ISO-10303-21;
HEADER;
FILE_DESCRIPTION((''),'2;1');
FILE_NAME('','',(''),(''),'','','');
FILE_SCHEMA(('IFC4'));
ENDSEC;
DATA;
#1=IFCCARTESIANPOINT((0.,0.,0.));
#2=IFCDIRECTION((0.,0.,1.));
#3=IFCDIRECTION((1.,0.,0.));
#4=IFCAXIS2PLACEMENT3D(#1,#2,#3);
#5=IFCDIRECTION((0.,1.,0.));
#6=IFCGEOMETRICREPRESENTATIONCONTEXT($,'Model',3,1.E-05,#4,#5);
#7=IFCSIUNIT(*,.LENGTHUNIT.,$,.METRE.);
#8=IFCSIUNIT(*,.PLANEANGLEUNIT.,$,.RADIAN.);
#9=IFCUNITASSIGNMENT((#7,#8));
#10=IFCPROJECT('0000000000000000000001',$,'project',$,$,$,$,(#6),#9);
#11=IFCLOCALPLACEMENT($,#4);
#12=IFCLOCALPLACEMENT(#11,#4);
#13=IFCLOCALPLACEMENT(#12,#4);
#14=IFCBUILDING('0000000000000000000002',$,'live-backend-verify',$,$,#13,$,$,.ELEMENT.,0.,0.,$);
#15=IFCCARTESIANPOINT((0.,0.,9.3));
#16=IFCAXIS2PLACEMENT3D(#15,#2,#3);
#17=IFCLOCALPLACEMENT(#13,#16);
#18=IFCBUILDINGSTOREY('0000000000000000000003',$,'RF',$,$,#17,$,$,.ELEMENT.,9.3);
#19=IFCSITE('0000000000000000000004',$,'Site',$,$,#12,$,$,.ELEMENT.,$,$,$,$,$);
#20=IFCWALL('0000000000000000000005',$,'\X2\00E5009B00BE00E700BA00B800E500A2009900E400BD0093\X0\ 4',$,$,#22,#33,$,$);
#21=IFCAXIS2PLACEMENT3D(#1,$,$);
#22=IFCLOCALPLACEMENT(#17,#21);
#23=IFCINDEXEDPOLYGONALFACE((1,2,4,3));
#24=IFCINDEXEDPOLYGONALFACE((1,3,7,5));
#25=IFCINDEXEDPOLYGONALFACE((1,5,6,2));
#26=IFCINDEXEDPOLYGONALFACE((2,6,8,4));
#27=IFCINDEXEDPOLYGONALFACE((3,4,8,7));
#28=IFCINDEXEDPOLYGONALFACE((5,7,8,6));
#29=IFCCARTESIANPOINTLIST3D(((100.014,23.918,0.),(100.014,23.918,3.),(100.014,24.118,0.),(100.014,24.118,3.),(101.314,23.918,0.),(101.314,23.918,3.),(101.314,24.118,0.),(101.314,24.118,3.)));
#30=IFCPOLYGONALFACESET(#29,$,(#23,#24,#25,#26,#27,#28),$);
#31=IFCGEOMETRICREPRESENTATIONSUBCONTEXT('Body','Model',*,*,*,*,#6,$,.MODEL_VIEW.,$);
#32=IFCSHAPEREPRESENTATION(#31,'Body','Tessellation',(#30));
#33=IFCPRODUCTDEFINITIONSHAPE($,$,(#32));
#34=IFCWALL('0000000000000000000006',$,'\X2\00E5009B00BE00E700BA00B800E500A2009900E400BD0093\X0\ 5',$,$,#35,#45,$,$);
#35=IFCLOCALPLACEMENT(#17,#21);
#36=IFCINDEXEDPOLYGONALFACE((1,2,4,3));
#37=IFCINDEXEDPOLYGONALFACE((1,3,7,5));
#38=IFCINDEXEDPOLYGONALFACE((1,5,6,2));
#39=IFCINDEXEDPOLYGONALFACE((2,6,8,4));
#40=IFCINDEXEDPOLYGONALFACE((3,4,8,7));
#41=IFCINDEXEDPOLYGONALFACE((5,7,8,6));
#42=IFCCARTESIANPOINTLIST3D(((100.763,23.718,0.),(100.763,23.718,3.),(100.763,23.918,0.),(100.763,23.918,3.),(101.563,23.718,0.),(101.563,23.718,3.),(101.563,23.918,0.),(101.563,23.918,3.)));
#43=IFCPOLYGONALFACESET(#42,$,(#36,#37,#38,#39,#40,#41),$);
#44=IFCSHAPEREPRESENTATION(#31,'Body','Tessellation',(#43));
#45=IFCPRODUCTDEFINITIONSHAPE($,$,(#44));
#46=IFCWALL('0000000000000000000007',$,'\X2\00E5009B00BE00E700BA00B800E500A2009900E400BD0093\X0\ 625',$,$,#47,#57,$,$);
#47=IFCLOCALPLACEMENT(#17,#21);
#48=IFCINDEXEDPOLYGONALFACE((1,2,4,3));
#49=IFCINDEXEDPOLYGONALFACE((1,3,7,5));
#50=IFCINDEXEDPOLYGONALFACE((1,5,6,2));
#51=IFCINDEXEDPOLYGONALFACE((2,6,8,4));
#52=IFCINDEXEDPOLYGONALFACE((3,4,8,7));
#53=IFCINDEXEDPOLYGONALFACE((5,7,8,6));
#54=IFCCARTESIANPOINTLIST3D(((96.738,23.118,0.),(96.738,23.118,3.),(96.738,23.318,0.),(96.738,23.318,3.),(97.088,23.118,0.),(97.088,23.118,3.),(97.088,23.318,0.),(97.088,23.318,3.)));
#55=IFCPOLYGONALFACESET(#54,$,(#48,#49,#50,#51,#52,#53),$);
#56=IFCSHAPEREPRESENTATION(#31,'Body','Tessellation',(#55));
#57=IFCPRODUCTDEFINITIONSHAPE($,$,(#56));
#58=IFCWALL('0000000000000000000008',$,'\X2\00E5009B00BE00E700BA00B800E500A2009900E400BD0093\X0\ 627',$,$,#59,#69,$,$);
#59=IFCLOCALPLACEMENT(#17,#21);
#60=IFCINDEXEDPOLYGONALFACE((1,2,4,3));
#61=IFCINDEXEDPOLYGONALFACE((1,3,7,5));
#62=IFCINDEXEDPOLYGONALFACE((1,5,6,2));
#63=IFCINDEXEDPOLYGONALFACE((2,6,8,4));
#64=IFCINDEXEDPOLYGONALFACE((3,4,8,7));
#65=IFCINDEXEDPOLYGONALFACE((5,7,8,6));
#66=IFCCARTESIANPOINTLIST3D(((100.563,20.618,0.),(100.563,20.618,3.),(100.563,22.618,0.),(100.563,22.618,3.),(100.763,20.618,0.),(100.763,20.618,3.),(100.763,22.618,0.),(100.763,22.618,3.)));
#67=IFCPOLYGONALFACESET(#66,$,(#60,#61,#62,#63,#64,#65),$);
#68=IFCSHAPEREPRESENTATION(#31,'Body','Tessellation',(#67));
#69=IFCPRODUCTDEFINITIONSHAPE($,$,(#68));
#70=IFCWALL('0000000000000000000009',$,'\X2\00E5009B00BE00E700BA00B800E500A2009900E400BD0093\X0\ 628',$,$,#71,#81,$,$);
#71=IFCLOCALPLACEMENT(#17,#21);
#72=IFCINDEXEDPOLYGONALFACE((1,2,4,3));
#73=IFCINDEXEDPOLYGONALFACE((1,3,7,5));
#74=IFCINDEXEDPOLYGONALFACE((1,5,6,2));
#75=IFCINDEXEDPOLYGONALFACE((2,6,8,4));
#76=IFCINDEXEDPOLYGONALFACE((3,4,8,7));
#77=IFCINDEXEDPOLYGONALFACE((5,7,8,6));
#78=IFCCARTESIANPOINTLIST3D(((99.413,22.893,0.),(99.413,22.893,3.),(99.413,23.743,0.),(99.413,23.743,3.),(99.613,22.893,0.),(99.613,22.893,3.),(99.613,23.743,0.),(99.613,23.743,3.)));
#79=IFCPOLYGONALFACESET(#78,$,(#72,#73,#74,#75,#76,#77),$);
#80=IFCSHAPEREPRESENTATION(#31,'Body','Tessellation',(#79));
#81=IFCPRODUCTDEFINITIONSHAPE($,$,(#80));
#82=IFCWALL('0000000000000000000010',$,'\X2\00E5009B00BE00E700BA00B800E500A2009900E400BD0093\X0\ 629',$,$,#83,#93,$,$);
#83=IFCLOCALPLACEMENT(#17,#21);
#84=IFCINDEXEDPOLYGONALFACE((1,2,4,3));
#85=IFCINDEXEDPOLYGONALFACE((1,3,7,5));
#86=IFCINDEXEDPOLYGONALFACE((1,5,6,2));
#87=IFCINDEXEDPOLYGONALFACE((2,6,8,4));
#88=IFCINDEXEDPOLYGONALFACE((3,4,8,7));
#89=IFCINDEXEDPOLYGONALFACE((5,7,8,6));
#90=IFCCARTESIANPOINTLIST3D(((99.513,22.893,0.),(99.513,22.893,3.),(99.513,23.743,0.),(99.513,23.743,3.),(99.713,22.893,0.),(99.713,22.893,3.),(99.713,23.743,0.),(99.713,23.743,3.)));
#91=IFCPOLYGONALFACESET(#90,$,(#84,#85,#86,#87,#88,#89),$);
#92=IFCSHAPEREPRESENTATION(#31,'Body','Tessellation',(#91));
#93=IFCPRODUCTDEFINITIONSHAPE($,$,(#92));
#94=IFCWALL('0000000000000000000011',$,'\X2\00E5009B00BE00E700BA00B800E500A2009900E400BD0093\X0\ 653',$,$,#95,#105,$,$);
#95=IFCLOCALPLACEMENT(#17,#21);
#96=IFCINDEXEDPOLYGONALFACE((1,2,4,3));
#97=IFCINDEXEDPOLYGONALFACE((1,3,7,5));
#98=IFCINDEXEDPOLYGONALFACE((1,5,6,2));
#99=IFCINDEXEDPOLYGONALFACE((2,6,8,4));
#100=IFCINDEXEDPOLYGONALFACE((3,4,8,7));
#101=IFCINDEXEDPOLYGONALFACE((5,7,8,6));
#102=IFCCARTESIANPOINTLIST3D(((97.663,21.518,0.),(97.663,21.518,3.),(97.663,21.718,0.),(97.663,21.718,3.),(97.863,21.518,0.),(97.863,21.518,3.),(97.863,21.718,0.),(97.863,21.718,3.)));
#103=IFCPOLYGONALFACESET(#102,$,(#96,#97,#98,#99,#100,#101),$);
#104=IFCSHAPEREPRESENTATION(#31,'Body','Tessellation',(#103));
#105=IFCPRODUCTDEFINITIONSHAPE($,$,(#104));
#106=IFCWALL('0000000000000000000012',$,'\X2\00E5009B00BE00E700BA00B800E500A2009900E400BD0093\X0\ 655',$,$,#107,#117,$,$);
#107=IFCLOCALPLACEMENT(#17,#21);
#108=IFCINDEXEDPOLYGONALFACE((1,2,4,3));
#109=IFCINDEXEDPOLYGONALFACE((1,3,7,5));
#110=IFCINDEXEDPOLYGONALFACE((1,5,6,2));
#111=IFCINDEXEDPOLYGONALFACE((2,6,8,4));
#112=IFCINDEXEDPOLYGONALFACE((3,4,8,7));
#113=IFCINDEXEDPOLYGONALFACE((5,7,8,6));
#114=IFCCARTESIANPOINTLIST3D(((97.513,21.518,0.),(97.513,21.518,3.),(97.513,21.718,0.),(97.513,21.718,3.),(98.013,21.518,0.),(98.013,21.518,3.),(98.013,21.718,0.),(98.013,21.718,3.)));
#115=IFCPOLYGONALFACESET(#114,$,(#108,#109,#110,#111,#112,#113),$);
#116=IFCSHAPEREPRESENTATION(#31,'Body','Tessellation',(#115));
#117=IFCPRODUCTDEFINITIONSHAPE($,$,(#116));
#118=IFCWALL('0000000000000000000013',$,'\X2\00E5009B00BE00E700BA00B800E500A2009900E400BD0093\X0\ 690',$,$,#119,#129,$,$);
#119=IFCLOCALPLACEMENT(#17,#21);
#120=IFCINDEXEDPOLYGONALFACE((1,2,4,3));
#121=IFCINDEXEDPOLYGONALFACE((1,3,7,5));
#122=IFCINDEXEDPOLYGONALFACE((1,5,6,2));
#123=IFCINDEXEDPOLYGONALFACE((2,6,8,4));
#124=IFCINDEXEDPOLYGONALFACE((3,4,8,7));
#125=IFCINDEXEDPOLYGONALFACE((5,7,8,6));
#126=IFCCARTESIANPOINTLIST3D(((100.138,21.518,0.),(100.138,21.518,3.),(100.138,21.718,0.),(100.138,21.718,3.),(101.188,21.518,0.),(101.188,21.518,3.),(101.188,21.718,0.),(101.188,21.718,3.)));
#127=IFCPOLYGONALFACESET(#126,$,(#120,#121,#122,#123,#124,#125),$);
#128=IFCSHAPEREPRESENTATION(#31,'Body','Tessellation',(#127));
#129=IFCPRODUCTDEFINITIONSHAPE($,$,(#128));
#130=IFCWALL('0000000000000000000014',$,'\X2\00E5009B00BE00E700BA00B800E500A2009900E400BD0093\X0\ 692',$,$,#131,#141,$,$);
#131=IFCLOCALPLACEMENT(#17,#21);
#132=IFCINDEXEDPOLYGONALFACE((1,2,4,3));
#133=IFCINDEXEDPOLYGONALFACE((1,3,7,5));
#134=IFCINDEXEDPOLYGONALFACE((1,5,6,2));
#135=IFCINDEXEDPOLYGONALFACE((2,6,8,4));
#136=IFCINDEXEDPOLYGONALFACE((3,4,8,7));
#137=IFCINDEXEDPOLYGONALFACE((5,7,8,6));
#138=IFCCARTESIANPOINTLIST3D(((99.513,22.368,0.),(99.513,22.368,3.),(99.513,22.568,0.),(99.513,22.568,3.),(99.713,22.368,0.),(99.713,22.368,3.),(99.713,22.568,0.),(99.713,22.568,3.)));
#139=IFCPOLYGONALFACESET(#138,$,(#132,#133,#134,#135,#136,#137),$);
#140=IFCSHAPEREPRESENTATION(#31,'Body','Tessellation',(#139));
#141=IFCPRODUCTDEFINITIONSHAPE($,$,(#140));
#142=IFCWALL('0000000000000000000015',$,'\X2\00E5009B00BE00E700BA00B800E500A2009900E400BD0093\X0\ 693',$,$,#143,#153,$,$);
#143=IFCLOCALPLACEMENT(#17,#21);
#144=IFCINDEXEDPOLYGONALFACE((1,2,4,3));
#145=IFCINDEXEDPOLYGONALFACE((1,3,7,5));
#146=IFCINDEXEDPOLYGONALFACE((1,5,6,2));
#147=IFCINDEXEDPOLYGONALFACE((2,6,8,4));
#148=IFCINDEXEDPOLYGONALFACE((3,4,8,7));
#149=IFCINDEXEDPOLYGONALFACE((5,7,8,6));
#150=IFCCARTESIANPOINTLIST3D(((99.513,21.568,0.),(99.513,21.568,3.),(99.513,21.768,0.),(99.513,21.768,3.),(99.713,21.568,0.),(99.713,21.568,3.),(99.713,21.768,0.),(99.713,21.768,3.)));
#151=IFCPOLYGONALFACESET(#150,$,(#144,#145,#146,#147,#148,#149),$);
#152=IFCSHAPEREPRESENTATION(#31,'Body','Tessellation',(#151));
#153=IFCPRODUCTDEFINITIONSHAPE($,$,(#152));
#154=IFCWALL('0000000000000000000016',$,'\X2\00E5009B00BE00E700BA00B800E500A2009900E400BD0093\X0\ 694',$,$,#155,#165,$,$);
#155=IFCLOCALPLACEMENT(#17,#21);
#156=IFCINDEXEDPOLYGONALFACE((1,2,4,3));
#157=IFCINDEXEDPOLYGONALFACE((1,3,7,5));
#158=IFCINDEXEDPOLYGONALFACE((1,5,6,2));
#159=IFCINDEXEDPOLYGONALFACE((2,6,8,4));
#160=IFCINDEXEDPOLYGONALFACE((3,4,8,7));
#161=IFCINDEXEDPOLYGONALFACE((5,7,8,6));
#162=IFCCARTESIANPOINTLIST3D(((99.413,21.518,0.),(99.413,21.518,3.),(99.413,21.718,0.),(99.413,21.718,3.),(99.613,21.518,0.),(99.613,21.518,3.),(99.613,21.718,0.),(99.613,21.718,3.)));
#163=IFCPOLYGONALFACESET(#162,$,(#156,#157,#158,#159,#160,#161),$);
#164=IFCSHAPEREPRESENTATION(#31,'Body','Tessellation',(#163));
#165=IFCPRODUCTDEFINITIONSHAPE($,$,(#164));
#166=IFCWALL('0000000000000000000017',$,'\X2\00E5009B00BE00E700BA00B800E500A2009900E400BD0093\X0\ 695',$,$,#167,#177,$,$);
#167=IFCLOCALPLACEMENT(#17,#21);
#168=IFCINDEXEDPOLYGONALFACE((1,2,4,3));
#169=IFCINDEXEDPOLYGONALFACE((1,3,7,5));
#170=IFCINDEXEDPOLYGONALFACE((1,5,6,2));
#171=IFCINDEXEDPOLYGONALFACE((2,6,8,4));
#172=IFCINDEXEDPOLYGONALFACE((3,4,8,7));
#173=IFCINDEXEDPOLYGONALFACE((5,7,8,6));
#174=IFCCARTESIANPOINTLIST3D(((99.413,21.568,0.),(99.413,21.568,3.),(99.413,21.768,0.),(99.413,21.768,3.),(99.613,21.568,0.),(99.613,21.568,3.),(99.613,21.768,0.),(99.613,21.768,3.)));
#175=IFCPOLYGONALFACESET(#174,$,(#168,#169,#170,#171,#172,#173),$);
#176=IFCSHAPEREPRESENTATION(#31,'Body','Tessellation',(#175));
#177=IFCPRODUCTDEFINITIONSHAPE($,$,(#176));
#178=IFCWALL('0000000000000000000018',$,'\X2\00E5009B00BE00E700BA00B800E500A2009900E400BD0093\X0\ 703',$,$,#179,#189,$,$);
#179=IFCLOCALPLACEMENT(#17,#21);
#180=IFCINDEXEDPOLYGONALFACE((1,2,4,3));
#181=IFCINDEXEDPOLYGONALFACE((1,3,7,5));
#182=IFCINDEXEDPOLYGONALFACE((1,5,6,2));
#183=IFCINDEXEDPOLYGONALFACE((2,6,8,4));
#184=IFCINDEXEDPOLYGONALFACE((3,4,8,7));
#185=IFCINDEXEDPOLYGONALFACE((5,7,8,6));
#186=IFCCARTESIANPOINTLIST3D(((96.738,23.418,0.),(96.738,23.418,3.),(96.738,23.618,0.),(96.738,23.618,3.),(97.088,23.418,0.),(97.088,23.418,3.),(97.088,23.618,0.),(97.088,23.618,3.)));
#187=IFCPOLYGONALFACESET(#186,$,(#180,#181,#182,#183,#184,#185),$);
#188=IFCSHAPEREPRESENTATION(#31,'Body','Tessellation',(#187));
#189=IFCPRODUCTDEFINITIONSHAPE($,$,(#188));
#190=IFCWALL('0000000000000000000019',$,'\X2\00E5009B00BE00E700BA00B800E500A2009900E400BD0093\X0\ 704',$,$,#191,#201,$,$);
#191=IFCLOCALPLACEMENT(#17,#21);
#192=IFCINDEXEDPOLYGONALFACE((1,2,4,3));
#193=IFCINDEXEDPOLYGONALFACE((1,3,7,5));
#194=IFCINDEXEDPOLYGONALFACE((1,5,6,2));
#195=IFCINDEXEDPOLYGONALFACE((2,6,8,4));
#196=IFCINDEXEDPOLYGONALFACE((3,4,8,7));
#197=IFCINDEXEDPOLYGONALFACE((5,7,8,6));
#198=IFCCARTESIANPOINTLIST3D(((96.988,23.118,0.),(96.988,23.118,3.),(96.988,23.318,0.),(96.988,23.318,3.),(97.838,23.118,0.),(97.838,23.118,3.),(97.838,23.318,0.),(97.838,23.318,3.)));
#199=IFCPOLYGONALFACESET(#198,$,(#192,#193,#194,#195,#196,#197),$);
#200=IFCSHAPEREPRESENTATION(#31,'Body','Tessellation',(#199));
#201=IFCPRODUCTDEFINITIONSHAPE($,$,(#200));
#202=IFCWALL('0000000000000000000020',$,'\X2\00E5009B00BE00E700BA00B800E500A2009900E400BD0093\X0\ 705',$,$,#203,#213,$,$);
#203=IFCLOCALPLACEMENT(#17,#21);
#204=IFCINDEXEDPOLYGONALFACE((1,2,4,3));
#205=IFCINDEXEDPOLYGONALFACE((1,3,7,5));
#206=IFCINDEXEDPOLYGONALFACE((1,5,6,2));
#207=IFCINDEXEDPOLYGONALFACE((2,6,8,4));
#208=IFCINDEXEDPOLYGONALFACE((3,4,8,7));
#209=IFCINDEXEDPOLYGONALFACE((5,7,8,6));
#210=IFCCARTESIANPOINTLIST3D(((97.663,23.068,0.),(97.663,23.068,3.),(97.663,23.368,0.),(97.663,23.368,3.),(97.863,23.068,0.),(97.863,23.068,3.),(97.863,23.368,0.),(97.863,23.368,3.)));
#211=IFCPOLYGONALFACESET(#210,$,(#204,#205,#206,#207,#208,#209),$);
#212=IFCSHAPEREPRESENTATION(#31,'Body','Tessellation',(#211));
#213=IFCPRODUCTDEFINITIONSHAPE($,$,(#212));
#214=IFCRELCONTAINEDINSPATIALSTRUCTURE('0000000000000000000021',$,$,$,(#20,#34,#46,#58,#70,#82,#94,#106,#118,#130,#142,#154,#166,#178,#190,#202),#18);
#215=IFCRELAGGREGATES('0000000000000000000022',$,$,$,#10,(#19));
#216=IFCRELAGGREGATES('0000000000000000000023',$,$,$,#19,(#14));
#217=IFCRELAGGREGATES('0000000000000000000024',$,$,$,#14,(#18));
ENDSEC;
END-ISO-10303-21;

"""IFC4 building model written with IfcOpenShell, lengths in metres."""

from ifc_helpers import new_model, si_unit, direction, frame, frame_2d, origin_with_axes, place, context, subcontext, project, spatial, rectangle, extrude, element, save


model = new_model("IFC4")

# Units and contexts
model_context = context("Model", 3, precision=1e-05, world=origin_with_axes(), true_north=direction((0.0, 1.0, 0.0)))
body_context = subcontext(model_context, "Body", "Model", "MODEL_VIEW")
ifc_project = project(units=[si_unit("LENGTHUNIT", "METRE"), si_unit("PLANEANGLEUNIT", "RADIAN")], contexts=[model_context])

# Site, building, storey
placement = place(None, origin_with_axes())
site_placement = place(placement, origin_with_axes())
site = spatial("IfcSite", under=ifc_project, at=site_placement, Name="Site", CompositionType="ELEMENT")
building_placement = place(site_placement, origin_with_axes())
building = spatial("IfcBuilding", under=site, at=building_placement, Name="live-backend-verify", CompositionType="ELEMENT", ElevationOfRefHeight=0.0, ElevationOfTerrain=0.0)
storey_placement = place(building_placement, frame((0.0, 0.0, 9.3), z_axis=(0.0, 0.0, 1.0), x_axis=(1.0, 0.0, 0.0)))
storey = spatial("IfcBuildingStorey", under=building, at=storey_placement, Name="RF", CompositionType="ELEMENT", Elevation=9.3)

# Walls
wall_1_placement = place(storey_placement, frame((100.664, 24.018, 0.0), z_axis=(0.0, 0.0, 1.0), x_axis=(1.0, 0.0, 0.0)))
element("IfcWall", 1, at=wall_1_placement, inside=storey, Name="å\u009b¾çº¸å¢\u0099ä½\u0093 4", context=body_context, shape_type="SweptSolid", body=[
    extrude(rectangle(XDim=1.3, YDim=0.2, at=frame_2d((0.0, 0.0), x_axis=(1.0, 0.0, 0.0))), frame((0.0, 0.0, 0.0), z_axis=(0.0, 0.0, 1.0)), (0.0, 0.0, 1.0), 3.0),
])
wall_2_placement = place(storey_placement, frame((101.163, 23.818, 0.0), z_axis=(0.0, 0.0, 1.0), x_axis=(1.0, 0.0, 0.0)))
element("IfcWall", 2, at=wall_2_placement, inside=storey, Name="å\u009b¾çº¸å¢\u0099ä½\u0093 5", context=body_context, shape_type="SweptSolid", body=[
    extrude(rectangle(XDim=0.8, YDim=0.2, at=frame_2d((0.0, 0.0), x_axis=(1.0, 0.0, 0.0))), frame((0.0, 0.0, 0.0), z_axis=(0.0, 0.0, 1.0)), (0.0, 0.0, 1.0), 3.0),
])
wall_3_placement = place(storey_placement, frame((96.913, 23.218, 0.0), z_axis=(0.0, 0.0, 1.0), x_axis=(-1.0, 0.0, 0.0)))
element("IfcWall", 3, at=wall_3_placement, inside=storey, Name="å\u009b¾çº¸å¢\u0099ä½\u0093 625", context=body_context, shape_type="SweptSolid", body=[
    extrude(rectangle(XDim=0.35, YDim=0.2, at=frame_2d((0.0, 0.0), x_axis=(1.0, 0.0, 0.0))), frame((0.0, 0.0, 0.0), z_axis=(0.0, 0.0, 1.0)), (0.0, 0.0, 1.0), 3.0),
])
wall_4_placement = place(storey_placement, frame((100.663, 21.618, 0.0), z_axis=(0.0, 0.0, 1.0), x_axis=(0.0, 1.0, 0.0)))
element("IfcWall", 4, at=wall_4_placement, inside=storey, Name="å\u009b¾çº¸å¢\u0099ä½\u0093 627", context=body_context, shape_type="SweptSolid", body=[
    extrude(rectangle(XDim=2.0, YDim=0.2, at=frame_2d((0.0, 0.0), x_axis=(1.0, 0.0, 0.0))), frame((0.0, 0.0, 0.0), z_axis=(0.0, 0.0, 1.0)), (0.0, 0.0, 1.0), 3.0),
])
for number, where, z_axis, x_axis, name in (
    (5, (99.513, 23.318, 0.0), (0.0, 0.0, 1.0), (0.0, -1.0, 0.0), "å\u009b¾çº¸å¢\u0099ä½\u0093 628"),
    (6, (99.613, 23.318, 0.0), (0.0, 0.0, 1.0), (0.0, -1.0, 0.0), "å\u009b¾çº¸å¢\u0099ä½\u0093 629"),
):
    element("IfcWall", number, at=place(storey_placement, frame(where, z_axis=z_axis, x_axis=x_axis)), inside=storey, Name=name, context=body_context, shape_type="SweptSolid", body=[
        extrude(rectangle(XDim=0.85, YDim=0.2, at=frame_2d((0.0, 0.0), x_axis=(1.0, 0.0, 0.0))), frame((0.0, 0.0, 0.0), z_axis=(0.0, 0.0, 1.0)), (0.0, 0.0, 1.0), 3.0),
    ])
wall_5_placement = place(storey_placement, frame((97.763, 21.618, 0.0), z_axis=(0.0, 0.0, 1.0), x_axis=(0.0, -1.0, 0.0)))
element("IfcWall", 7, at=wall_5_placement, inside=storey, Name="å\u009b¾çº¸å¢\u0099ä½\u0093 653", context=body_context, shape_type="SweptSolid", body=[
    extrude(rectangle(XDim=0.2, YDim=0.2, at=frame_2d((0.0, 0.0), x_axis=(1.0, 0.0, 0.0))), frame((0.0, 0.0, 0.0), z_axis=(0.0, 0.0, 1.0)), (0.0, 0.0, 1.0), 3.0),
])
wall_6_placement = place(storey_placement, frame((97.763, 21.618, 0.0), z_axis=(0.0, 0.0, 1.0), x_axis=(-1.0, 0.0, 0.0)))
element("IfcWall", 8, at=wall_6_placement, inside=storey, Name="å\u009b¾çº¸å¢\u0099ä½\u0093 655", context=body_context, shape_type="SweptSolid", body=[
    extrude(rectangle(XDim=0.5, YDim=0.2, at=frame_2d((0.0, 0.0), x_axis=(1.0, 0.0, 0.0))), frame((0.0, 0.0, 0.0), z_axis=(0.0, 0.0, 1.0)), (0.0, 0.0, 1.0), 3.0),
])
wall_7_placement = place(storey_placement, frame((100.663, 21.618, 0.0), z_axis=(0.0, 0.0, 1.0), x_axis=(-1.0, 0.0, 0.0)))
element("IfcWall", 9, at=wall_7_placement, inside=storey, Name="å\u009b¾çº¸å¢\u0099ä½\u0093 690", context=body_context, shape_type="SweptSolid", body=[
    extrude(rectangle(XDim=1.05, YDim=0.2, at=frame_2d((0.0, 0.0), x_axis=(1.0, 0.0, 0.0))), frame((0.0, 0.0, 0.0), z_axis=(0.0, 0.0, 1.0)), (0.0, 0.0, 1.0), 3.0),
])
for number, where, z_axis, x_axis, name in (
    (10, (99.613, 22.468, 0.0), (0.0, 0.0, 1.0), (-1.0, 0.0, 0.0), "å\u009b¾çº¸å¢\u0099ä½\u0093 692"),
    (11, (99.613, 21.668, 0.0), (0.0, 0.0, 1.0), (-1.0, 0.0, 0.0), "å\u009b¾çº¸å¢\u0099ä½\u0093 693"),
    (12, (99.513, 21.618, 0.0), (0.0, 0.0, 1.0), (0.0, -1.0, 0.0), "å\u009b¾çº¸å¢\u0099ä½\u0093 694"),
    (13, (99.513, 21.668, 0.0), (0.0, 0.0, 1.0), (0.0, -1.0, 0.0), "å\u009b¾çº¸å¢\u0099ä½\u0093 695"),
):
    element("IfcWall", number, at=place(storey_placement, frame(where, z_axis=z_axis, x_axis=x_axis)), inside=storey, Name=name, context=body_context, shape_type="SweptSolid", body=[
        extrude(rectangle(XDim=0.2, YDim=0.2, at=frame_2d((0.0, 0.0), x_axis=(1.0, 0.0, 0.0))), frame((0.0, 0.0, 0.0), z_axis=(0.0, 0.0, 1.0)), (0.0, 0.0, 1.0), 3.0),
    ])
wall_8_placement = place(storey_placement, frame((96.913, 23.518, 0.0), z_axis=(0.0, 0.0, 1.0), x_axis=(-1.0, 0.0, 0.0)))
element("IfcWall", 14, at=wall_8_placement, inside=storey, Name="å\u009b¾çº¸å¢\u0099ä½\u0093 703", context=body_context, shape_type="SweptSolid", body=[
    extrude(rectangle(XDim=0.35, YDim=0.2, at=frame_2d((0.0, 0.0), x_axis=(1.0, 0.0, 0.0))), frame((0.0, 0.0, 0.0), z_axis=(0.0, 0.0, 1.0)), (0.0, 0.0, 1.0), 3.0),
])
wall_9_placement = place(storey_placement, frame((97.413, 23.218, 0.0), z_axis=(0.0, 0.0, 1.0), x_axis=(-1.0, 0.0, 0.0)))
element("IfcWall", 15, at=wall_9_placement, inside=storey, Name="å\u009b¾çº¸å¢\u0099ä½\u0093 704", context=body_context, shape_type="SweptSolid", body=[
    extrude(rectangle(XDim=0.85, YDim=0.2, at=frame_2d((0.0, 0.0), x_axis=(1.0, 0.0, 0.0))), frame((0.0, 0.0, 0.0), z_axis=(0.0, 0.0, 1.0)), (0.0, 0.0, 1.0), 3.0),
])
wall_10_placement = place(storey_placement, frame((97.763, 23.218, 0.0), z_axis=(0.0, 0.0, 1.0), x_axis=(0.0, 1.0, 0.0)))
element("IfcWall", 16, at=wall_10_placement, inside=storey, Name="å\u009b¾çº¸å¢\u0099ä½\u0093 705", context=body_context, shape_type="SweptSolid", body=[
    extrude(rectangle(XDim=0.3, YDim=0.2, at=frame_2d((0.0, 0.0), x_axis=(1.0, 0.0, 0.0))), frame((0.0, 0.0, 0.0), z_axis=(0.0, 0.0, 1.0)), (0.0, 0.0, 1.0), 3.0),
])

save(model, "model.ifc")
